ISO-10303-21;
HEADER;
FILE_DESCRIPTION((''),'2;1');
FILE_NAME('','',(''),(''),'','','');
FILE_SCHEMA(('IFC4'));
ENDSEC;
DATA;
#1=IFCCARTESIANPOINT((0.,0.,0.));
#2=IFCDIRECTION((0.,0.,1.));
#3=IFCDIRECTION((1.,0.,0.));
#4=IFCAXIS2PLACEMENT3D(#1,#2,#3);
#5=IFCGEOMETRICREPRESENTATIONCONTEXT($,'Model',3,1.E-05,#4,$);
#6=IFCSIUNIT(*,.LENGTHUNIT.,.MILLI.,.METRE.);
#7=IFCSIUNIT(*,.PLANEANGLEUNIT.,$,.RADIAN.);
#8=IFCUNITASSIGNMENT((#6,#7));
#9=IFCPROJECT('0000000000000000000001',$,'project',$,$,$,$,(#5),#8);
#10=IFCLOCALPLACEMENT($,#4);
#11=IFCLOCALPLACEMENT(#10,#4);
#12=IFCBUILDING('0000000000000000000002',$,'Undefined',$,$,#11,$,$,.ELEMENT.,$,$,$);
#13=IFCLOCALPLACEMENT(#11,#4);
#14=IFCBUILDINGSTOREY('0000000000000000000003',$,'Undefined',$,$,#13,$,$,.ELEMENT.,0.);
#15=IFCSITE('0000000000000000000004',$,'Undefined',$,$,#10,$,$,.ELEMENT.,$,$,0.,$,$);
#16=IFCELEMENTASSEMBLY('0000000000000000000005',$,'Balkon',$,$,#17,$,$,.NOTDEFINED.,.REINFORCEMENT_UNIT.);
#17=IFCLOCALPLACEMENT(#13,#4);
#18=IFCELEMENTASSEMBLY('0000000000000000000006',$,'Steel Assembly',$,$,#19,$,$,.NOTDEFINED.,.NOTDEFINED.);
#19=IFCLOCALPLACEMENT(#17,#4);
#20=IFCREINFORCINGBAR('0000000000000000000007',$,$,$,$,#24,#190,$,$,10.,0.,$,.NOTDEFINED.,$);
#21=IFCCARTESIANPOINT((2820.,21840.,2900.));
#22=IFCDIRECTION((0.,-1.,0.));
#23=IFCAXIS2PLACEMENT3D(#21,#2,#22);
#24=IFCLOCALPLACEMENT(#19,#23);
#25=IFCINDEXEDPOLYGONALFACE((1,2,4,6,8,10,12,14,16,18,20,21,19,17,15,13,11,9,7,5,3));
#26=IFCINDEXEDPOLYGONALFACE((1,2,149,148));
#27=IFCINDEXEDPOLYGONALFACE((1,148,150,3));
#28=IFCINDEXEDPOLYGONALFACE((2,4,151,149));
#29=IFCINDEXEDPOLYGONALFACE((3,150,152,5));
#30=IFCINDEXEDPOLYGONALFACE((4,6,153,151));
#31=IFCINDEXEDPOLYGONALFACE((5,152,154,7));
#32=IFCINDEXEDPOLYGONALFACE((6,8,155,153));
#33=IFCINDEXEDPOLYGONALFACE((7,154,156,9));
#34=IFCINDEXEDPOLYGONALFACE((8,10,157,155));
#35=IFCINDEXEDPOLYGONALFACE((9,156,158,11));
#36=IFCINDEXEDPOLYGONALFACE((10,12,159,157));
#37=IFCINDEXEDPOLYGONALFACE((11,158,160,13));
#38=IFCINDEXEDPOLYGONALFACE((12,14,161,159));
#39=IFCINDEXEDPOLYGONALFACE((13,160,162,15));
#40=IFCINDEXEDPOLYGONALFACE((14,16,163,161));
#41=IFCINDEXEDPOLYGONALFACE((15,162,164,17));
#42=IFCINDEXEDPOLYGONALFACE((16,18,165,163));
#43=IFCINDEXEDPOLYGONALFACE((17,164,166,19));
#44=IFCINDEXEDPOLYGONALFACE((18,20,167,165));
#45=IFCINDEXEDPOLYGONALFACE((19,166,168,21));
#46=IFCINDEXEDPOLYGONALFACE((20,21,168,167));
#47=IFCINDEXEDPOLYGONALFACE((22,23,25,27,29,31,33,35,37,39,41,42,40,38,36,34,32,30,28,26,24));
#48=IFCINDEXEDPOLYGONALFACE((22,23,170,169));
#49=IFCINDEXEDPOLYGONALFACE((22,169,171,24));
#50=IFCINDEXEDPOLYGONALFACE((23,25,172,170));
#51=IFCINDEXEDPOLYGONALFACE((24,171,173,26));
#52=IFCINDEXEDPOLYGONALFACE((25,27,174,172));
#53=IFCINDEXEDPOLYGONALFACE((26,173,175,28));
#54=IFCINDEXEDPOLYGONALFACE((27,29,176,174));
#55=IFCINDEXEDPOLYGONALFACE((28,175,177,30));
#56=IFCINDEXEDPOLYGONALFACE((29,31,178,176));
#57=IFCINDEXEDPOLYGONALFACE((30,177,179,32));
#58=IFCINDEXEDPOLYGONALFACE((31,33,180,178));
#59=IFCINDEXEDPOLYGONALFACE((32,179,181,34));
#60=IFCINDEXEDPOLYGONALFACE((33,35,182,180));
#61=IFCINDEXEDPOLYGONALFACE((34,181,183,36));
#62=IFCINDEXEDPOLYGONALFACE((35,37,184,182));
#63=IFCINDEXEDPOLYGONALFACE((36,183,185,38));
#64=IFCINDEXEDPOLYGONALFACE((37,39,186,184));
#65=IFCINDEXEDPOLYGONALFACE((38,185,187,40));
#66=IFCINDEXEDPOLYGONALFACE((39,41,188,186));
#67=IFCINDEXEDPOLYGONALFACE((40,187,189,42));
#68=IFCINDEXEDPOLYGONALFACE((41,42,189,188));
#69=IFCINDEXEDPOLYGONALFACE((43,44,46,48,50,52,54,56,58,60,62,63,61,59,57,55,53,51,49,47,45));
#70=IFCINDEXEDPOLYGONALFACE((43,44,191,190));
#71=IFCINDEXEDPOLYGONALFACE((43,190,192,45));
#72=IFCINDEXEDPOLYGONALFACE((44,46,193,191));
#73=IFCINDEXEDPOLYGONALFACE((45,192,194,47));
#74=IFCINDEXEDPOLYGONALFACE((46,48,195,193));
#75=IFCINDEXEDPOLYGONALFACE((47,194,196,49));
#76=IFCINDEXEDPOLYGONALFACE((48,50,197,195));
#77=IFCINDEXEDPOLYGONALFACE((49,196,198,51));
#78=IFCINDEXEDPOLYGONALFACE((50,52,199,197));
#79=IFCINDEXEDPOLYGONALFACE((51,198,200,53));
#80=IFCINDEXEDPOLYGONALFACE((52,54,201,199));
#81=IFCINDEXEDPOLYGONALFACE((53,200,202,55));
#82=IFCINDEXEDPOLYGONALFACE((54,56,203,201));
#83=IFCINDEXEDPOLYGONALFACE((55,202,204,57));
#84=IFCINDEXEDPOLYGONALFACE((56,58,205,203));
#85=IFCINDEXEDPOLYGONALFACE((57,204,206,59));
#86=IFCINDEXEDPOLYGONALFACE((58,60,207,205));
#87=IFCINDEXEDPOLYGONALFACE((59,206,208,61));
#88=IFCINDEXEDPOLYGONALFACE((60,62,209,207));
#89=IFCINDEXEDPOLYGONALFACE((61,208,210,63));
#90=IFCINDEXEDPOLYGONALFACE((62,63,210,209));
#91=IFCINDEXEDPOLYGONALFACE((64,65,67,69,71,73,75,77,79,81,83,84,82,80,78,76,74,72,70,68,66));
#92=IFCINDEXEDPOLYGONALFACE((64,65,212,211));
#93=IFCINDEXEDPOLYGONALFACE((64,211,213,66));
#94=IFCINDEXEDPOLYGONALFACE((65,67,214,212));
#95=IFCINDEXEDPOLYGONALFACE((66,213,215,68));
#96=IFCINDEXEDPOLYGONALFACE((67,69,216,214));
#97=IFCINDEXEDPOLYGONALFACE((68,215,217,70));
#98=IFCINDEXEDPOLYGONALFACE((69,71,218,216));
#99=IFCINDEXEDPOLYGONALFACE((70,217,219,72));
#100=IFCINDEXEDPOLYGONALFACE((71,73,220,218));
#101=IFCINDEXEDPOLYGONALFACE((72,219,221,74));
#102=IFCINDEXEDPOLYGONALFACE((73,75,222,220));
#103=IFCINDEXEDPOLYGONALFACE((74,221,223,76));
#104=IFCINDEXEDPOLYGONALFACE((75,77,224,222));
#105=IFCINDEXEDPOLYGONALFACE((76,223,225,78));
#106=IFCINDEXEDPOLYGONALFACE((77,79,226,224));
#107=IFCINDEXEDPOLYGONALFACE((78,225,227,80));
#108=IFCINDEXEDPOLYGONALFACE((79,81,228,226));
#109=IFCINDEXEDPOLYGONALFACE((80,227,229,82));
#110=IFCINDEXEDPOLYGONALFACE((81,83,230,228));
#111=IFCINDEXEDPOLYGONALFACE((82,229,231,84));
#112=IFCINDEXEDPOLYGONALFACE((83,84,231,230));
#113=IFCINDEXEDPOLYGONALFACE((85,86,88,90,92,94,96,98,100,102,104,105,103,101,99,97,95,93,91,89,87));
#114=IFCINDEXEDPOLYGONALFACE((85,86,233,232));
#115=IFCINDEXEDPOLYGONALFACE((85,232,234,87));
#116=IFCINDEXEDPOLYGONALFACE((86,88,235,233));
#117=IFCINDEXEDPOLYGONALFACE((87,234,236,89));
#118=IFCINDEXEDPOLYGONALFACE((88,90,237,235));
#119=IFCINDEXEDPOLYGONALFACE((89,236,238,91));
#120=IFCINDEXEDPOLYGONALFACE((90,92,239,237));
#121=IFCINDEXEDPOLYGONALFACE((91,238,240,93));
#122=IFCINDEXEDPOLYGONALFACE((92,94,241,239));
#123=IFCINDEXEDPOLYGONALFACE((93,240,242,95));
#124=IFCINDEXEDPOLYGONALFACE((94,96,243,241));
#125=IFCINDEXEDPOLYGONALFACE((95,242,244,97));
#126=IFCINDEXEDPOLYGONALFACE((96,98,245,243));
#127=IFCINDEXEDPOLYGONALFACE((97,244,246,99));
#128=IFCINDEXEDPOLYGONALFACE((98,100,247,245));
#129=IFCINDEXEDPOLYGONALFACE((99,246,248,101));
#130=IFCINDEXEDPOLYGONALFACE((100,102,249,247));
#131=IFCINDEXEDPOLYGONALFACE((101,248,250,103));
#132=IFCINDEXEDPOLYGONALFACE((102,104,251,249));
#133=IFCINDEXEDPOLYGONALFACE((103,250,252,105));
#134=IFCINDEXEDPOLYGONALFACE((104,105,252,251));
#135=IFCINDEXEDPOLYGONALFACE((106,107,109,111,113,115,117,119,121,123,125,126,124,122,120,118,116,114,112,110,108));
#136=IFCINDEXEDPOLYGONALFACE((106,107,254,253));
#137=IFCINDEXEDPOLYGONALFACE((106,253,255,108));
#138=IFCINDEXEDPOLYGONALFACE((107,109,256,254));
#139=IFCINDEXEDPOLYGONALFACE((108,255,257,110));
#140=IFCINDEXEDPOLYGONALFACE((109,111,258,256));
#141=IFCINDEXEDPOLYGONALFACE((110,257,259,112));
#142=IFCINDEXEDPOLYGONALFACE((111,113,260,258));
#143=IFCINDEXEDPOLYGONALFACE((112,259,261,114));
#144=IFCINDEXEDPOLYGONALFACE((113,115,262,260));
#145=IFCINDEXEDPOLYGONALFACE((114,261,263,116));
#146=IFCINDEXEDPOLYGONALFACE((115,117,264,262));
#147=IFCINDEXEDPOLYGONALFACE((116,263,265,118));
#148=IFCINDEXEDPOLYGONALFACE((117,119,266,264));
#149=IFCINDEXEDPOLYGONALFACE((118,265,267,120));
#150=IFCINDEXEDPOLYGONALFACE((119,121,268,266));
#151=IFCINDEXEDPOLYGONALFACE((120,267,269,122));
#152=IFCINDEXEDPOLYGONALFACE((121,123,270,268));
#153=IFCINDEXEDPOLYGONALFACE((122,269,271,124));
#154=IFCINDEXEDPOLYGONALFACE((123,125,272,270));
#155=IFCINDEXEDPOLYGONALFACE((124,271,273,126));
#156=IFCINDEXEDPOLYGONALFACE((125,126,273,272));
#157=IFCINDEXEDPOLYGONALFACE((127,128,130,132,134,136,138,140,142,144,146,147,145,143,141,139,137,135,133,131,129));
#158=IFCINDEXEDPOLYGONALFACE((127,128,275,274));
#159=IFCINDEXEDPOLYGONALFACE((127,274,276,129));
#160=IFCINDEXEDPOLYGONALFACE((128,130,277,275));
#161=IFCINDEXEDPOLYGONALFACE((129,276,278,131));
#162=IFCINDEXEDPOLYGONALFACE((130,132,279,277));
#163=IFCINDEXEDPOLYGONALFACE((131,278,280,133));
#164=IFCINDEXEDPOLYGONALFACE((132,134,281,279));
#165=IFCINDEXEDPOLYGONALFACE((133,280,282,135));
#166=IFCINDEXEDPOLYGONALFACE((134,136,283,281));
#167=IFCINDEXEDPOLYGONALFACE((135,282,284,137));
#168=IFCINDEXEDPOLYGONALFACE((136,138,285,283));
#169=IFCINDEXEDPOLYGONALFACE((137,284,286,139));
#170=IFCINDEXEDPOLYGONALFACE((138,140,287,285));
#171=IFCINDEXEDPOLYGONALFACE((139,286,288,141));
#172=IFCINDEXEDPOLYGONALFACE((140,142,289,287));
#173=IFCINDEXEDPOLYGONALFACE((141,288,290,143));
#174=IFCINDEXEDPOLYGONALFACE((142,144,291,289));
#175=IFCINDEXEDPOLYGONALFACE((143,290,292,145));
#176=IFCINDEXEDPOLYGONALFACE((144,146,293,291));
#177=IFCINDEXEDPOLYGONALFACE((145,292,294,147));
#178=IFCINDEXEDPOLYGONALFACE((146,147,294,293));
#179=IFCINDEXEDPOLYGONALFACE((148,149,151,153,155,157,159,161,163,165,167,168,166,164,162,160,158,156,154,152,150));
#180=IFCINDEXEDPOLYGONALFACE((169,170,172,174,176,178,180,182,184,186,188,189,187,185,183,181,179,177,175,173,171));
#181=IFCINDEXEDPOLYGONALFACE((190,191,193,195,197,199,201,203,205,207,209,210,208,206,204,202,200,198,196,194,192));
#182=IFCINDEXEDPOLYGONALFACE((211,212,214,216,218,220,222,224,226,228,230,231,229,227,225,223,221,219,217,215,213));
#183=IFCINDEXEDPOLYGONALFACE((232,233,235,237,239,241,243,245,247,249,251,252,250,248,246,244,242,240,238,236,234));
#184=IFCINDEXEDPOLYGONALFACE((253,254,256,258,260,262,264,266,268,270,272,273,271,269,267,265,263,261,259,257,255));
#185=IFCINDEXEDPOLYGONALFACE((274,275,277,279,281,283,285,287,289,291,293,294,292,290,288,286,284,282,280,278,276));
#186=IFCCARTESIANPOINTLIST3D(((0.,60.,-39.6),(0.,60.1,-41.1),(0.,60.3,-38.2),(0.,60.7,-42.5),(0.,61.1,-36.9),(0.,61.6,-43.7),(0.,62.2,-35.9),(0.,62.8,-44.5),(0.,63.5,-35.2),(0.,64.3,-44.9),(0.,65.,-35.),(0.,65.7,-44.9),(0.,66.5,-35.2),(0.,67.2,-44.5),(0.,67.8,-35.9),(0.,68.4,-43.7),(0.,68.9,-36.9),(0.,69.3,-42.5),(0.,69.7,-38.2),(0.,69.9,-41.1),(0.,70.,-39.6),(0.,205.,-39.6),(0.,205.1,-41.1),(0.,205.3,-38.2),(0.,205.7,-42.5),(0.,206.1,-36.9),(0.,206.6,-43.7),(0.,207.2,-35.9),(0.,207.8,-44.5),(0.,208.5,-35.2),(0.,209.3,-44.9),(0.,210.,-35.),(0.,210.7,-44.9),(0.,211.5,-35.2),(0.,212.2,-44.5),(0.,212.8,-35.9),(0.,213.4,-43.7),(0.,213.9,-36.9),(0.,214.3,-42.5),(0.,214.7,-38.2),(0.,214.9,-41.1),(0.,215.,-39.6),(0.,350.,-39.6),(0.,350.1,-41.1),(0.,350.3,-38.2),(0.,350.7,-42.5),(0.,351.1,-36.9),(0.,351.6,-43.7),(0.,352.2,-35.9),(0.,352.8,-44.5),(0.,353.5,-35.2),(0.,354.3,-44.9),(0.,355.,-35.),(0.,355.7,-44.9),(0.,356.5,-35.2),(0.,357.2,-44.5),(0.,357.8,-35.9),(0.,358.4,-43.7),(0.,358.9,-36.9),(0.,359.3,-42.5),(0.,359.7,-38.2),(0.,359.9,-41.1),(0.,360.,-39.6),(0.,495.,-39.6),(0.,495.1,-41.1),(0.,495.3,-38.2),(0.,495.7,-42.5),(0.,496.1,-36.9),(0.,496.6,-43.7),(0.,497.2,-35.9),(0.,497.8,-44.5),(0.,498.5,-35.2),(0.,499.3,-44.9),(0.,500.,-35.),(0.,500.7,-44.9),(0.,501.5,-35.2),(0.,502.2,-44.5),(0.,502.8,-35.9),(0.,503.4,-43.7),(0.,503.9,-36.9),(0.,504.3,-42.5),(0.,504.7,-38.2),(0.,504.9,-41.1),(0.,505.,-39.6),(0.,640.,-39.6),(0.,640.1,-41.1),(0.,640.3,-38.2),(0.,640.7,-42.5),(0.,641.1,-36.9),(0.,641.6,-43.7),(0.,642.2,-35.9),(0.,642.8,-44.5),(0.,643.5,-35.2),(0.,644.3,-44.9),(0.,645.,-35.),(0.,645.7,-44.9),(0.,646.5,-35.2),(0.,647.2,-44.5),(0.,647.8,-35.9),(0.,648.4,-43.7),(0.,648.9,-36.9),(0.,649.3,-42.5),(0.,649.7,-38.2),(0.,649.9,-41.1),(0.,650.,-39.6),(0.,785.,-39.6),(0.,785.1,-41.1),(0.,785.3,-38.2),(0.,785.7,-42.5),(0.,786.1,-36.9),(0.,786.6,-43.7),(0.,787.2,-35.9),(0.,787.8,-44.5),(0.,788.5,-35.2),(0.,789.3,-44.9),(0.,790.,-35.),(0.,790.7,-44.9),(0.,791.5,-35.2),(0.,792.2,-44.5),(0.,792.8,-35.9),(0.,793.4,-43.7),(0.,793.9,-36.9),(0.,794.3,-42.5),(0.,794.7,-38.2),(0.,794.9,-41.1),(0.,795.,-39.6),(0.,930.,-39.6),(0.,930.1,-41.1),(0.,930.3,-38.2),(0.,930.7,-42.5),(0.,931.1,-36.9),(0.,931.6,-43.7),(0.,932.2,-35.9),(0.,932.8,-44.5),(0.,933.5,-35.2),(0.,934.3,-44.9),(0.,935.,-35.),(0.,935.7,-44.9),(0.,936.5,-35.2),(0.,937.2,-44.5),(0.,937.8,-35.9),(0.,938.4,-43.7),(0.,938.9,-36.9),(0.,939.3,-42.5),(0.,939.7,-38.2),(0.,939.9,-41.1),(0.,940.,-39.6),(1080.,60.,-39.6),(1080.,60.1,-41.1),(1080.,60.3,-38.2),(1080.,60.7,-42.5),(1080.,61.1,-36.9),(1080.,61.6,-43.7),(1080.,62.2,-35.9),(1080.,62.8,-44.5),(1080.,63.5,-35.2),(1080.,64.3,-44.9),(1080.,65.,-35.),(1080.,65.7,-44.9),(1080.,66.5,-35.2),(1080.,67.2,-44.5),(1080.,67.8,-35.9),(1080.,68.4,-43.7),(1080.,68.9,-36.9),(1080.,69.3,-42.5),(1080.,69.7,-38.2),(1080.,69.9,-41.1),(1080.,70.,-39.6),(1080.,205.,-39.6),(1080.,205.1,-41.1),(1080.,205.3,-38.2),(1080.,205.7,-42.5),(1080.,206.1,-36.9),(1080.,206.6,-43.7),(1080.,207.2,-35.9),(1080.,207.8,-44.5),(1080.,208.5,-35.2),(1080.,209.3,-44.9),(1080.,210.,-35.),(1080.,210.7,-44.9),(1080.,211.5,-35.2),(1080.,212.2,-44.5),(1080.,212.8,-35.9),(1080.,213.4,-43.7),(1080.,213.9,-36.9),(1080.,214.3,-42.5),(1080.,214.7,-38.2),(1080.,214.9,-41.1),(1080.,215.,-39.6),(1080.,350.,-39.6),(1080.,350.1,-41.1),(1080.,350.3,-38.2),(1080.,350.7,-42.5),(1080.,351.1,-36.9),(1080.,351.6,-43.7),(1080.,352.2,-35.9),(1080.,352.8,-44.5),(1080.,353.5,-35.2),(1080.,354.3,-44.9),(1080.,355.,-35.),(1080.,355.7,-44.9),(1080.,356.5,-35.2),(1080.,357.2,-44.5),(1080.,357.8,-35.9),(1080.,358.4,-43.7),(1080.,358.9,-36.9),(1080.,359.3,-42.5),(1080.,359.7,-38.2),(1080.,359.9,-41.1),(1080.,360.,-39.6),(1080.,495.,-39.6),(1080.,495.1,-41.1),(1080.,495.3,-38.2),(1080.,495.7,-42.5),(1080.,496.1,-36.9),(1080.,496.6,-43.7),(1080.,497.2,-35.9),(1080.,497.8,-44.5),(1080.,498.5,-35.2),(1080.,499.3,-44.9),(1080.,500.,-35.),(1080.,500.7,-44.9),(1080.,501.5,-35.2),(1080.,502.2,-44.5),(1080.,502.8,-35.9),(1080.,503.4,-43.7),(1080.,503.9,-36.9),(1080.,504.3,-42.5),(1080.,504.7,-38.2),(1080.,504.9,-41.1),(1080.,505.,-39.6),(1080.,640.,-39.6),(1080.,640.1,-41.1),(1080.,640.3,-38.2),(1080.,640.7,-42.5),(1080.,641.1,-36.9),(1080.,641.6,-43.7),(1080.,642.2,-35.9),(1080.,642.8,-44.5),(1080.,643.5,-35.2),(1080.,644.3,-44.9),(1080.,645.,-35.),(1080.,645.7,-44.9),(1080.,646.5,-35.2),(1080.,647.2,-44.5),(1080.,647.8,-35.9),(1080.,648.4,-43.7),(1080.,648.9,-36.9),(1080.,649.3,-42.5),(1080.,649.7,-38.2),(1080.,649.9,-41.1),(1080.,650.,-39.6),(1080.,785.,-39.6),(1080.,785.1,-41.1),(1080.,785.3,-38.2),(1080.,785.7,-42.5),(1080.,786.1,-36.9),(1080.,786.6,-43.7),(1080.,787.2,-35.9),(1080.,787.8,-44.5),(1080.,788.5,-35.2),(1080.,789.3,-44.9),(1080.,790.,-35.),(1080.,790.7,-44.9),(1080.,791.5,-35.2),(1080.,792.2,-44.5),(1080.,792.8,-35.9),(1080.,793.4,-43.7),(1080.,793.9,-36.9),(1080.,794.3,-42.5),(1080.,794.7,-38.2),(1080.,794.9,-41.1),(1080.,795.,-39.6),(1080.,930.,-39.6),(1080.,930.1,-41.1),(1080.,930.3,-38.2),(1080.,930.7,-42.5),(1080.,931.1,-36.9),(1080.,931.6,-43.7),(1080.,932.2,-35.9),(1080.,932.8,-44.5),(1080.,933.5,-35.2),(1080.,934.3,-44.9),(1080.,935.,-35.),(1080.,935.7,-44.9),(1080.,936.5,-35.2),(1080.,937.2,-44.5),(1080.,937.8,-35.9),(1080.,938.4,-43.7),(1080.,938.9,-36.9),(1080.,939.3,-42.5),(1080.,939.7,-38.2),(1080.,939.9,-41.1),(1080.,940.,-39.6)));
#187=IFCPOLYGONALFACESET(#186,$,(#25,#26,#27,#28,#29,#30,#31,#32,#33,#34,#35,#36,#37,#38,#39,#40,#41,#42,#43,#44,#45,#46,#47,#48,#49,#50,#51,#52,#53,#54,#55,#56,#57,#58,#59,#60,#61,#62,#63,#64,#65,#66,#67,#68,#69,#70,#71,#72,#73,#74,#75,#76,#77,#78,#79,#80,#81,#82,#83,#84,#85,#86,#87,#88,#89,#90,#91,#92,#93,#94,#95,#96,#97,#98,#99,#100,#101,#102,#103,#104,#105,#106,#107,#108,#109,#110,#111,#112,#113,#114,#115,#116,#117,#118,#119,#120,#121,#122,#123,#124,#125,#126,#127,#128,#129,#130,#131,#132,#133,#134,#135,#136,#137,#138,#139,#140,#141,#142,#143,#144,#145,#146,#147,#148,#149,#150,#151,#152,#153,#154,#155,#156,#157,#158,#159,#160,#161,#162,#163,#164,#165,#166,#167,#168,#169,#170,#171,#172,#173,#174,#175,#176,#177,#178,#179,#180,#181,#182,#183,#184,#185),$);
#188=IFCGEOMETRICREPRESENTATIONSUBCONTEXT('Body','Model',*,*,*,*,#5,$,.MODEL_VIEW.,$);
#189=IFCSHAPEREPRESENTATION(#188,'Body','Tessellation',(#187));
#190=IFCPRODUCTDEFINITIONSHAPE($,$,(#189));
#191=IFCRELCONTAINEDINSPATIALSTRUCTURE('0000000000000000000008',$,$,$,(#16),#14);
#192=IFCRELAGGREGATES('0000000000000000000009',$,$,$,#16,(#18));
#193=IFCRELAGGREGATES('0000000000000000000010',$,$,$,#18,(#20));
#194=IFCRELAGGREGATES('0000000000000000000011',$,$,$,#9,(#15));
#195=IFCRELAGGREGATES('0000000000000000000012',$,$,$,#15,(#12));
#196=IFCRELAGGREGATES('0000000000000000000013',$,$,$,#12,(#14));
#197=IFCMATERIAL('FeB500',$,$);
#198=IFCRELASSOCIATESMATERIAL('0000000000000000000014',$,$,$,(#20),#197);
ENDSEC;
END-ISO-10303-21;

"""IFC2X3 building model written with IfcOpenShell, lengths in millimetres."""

from ifc_helpers import new_model, entity, si_unit, frame, origin_with_axes, place, context, subcontext, project, spatial, source, transform, mapped, material, element, aggregate, save


model = new_model("IFC2X3")

# Units and contexts
model_context = context("Model", 3, precision=1e-05, world=origin_with_axes())
body_context = subcontext(model_context, "Body", "Model", "MODEL_VIEW")
ifc_project = project(units=[si_unit("LENGTHUNIT", "METRE", prefix="MILLI"), si_unit("PLANEANGLEUNIT", "RADIAN")], contexts=[model_context])

# Site, building, storey
site_placement = place(None, origin_with_axes())
site = spatial("IfcSite", under=ifc_project, at=site_placement, Name="Undefined", CompositionType="ELEMENT", RefElevation=0.0)
building_placement = place(site_placement, origin_with_axes())
building = spatial("IfcBuilding", under=site, at=building_placement, Name="Undefined", CompositionType="ELEMENT")
storey_placement = place(building_placement, origin_with_axes())
storey = spatial("IfcBuildingStorey", under=building, at=storey_placement, Name="Undefined", CompositionType="ELEMENT", Elevation=0.0)

# Element assemblies, reinforcing bar
assembly_1_placement = place(storey_placement, origin_with_axes())
assembly_1 = element("IfcElementAssembly", 1, at=assembly_1_placement, inside=storey, Name="Balkon", AssemblyPlace="NOTDEFINED", PredefinedType="REINFORCEMENT_UNIT")
ifc_material_1 = material(Name="FeB500")
assembly_2_placement = place(assembly_1_placement, origin_with_axes())
assembly_2 = element("IfcElementAssembly", 2, at=assembly_2_placement, Name="Steel Assembly", AssemblyPlace="NOTDEFINED", PredefinedType="NOTDEFINED")
aggregate(assembly_1, [assembly_2])
shared_shape_1 = source(origin_with_axes(), body_context, "Body", "AdvancedSweptSolid", [
    entity("IfcSweptDiskSolid", entity("IfcTrimmedCurve", entity("IfcLine", entity("IfcCartesianPoint", [0.0, 0.0, 0.0]), entity("IfcVector", entity("IfcDirection", [1.0, 0.0, 0.0]), 1.0)), [entity("IfcParameterValue", 0.0)], [entity("IfcParameterValue", 1080.0)], True, "PARAMETER"), 5.0, None, 0.0, 1080.0),
])
shared_shape_2 = source(origin_with_axes(), body_context, "Body", "AdvancedSweptSolid", [
    entity("IfcSweptDiskSolid", entity("IfcTrimmedCurve", entity("IfcLine", entity("IfcCartesianPoint", [0.0, 0.0, 0.0]), entity("IfcVector", entity("IfcDirection", [1.0, 0.0, 0.0]), 1.0)), [entity("IfcParameterValue", 0.0)], [entity("IfcParameterValue", 1080.0)], True, "PARAMETER"), 5.0, None, 0.0, 1080.0),
])
shared_shape_3 = source(origin_with_axes(), body_context, "Body", "AdvancedSweptSolid", [
    entity("IfcSweptDiskSolid", entity("IfcTrimmedCurve", entity("IfcLine", entity("IfcCartesianPoint", [0.0, 0.0, 0.0]), entity("IfcVector", entity("IfcDirection", [1.0, 0.0, 0.0]), 1.0)), [entity("IfcParameterValue", 0.0)], [entity("IfcParameterValue", 1080.0)], True, "PARAMETER"), 5.0, None, 0.0, 1080.0),
])
shared_shape_4 = source(origin_with_axes(), body_context, "Body", "AdvancedSweptSolid", [
    entity("IfcSweptDiskSolid", entity("IfcTrimmedCurve", entity("IfcLine", entity("IfcCartesianPoint", [0.0, 0.0, 0.0]), entity("IfcVector", entity("IfcDirection", [1.0, 0.0, 0.0]), 1.0)), [entity("IfcParameterValue", 0.0)], [entity("IfcParameterValue", 1080.0)], True, "PARAMETER"), 5.0, None, 0.0, 1080.0),
])
shared_shape_5 = source(origin_with_axes(), body_context, "Body", "AdvancedSweptSolid", [
    entity("IfcSweptDiskSolid", entity("IfcTrimmedCurve", entity("IfcLine", entity("IfcCartesianPoint", [0.0, 0.0, 0.0]), entity("IfcVector", entity("IfcDirection", [1.0, 0.0, 0.0]), 1.0)), [entity("IfcParameterValue", 0.0)], [entity("IfcParameterValue", 1080.0)], True, "PARAMETER"), 5.0, None, 0.0, 1080.0),
])
shared_shape_6 = source(origin_with_axes(), body_context, "Body", "AdvancedSweptSolid", [
    entity("IfcSweptDiskSolid", entity("IfcTrimmedCurve", entity("IfcLine", entity("IfcCartesianPoint", [0.0, 0.0, 0.0]), entity("IfcVector", entity("IfcDirection", [1.0, 0.0, 0.0]), 1.0)), [entity("IfcParameterValue", 0.0)], [entity("IfcParameterValue", 1080.0)], True, "PARAMETER"), 5.0, None, 0.0, 1080.0),
])
shared_shape_7 = source(origin_with_axes(), body_context, "Body", "AdvancedSweptSolid", [
    entity("IfcSweptDiskSolid", entity("IfcTrimmedCurve", entity("IfcLine", entity("IfcCartesianPoint", [0.0, 0.0, 0.0]), entity("IfcVector", entity("IfcDirection", [1.0, 0.0, 0.0]), 1.0)), [entity("IfcParameterValue", 0.0)], [entity("IfcParameterValue", 1080.0)], True, "PARAMETER"), 5.0, None, 0.0, 1080.0),
])
reinforcing_bar_1_placement = place(assembly_2_placement, frame((2820.0, 21840.0, 2900.0), z_axis=(0.0, 0.0, 1.0), x_axis=(0.0, -1.0, 0.0)))
reinforcing_bar_1 = element("IfcReinforcingBar", 3, at=reinforcing_bar_1_placement, material=ifc_material_1, BarRole="NOTDEFINED", CrossSectionArea=0.0, NominalDiameter=10.0, context=body_context, shape_type="MappedRepresentation", body=[
    mapped(shared_shape_1, transform((0.0, 65.0, -40.0))),
    mapped(shared_shape_2, transform((0.0, 210.0, -40.0))),
    mapped(shared_shape_3, transform((0.0, 355.0, -40.0))),
    mapped(shared_shape_4, transform((0.0, 500.0, -40.0))),
    mapped(shared_shape_5, transform((0.0, 645.0, -40.0))),
    mapped(shared_shape_6, transform((0.0, 790.0, -40.0))),
    mapped(shared_shape_7, transform((0.0, 935.0, -40.0))),
])
aggregate(assembly_2, [reinforcing_bar_1])

save(model, "model.ifc")
